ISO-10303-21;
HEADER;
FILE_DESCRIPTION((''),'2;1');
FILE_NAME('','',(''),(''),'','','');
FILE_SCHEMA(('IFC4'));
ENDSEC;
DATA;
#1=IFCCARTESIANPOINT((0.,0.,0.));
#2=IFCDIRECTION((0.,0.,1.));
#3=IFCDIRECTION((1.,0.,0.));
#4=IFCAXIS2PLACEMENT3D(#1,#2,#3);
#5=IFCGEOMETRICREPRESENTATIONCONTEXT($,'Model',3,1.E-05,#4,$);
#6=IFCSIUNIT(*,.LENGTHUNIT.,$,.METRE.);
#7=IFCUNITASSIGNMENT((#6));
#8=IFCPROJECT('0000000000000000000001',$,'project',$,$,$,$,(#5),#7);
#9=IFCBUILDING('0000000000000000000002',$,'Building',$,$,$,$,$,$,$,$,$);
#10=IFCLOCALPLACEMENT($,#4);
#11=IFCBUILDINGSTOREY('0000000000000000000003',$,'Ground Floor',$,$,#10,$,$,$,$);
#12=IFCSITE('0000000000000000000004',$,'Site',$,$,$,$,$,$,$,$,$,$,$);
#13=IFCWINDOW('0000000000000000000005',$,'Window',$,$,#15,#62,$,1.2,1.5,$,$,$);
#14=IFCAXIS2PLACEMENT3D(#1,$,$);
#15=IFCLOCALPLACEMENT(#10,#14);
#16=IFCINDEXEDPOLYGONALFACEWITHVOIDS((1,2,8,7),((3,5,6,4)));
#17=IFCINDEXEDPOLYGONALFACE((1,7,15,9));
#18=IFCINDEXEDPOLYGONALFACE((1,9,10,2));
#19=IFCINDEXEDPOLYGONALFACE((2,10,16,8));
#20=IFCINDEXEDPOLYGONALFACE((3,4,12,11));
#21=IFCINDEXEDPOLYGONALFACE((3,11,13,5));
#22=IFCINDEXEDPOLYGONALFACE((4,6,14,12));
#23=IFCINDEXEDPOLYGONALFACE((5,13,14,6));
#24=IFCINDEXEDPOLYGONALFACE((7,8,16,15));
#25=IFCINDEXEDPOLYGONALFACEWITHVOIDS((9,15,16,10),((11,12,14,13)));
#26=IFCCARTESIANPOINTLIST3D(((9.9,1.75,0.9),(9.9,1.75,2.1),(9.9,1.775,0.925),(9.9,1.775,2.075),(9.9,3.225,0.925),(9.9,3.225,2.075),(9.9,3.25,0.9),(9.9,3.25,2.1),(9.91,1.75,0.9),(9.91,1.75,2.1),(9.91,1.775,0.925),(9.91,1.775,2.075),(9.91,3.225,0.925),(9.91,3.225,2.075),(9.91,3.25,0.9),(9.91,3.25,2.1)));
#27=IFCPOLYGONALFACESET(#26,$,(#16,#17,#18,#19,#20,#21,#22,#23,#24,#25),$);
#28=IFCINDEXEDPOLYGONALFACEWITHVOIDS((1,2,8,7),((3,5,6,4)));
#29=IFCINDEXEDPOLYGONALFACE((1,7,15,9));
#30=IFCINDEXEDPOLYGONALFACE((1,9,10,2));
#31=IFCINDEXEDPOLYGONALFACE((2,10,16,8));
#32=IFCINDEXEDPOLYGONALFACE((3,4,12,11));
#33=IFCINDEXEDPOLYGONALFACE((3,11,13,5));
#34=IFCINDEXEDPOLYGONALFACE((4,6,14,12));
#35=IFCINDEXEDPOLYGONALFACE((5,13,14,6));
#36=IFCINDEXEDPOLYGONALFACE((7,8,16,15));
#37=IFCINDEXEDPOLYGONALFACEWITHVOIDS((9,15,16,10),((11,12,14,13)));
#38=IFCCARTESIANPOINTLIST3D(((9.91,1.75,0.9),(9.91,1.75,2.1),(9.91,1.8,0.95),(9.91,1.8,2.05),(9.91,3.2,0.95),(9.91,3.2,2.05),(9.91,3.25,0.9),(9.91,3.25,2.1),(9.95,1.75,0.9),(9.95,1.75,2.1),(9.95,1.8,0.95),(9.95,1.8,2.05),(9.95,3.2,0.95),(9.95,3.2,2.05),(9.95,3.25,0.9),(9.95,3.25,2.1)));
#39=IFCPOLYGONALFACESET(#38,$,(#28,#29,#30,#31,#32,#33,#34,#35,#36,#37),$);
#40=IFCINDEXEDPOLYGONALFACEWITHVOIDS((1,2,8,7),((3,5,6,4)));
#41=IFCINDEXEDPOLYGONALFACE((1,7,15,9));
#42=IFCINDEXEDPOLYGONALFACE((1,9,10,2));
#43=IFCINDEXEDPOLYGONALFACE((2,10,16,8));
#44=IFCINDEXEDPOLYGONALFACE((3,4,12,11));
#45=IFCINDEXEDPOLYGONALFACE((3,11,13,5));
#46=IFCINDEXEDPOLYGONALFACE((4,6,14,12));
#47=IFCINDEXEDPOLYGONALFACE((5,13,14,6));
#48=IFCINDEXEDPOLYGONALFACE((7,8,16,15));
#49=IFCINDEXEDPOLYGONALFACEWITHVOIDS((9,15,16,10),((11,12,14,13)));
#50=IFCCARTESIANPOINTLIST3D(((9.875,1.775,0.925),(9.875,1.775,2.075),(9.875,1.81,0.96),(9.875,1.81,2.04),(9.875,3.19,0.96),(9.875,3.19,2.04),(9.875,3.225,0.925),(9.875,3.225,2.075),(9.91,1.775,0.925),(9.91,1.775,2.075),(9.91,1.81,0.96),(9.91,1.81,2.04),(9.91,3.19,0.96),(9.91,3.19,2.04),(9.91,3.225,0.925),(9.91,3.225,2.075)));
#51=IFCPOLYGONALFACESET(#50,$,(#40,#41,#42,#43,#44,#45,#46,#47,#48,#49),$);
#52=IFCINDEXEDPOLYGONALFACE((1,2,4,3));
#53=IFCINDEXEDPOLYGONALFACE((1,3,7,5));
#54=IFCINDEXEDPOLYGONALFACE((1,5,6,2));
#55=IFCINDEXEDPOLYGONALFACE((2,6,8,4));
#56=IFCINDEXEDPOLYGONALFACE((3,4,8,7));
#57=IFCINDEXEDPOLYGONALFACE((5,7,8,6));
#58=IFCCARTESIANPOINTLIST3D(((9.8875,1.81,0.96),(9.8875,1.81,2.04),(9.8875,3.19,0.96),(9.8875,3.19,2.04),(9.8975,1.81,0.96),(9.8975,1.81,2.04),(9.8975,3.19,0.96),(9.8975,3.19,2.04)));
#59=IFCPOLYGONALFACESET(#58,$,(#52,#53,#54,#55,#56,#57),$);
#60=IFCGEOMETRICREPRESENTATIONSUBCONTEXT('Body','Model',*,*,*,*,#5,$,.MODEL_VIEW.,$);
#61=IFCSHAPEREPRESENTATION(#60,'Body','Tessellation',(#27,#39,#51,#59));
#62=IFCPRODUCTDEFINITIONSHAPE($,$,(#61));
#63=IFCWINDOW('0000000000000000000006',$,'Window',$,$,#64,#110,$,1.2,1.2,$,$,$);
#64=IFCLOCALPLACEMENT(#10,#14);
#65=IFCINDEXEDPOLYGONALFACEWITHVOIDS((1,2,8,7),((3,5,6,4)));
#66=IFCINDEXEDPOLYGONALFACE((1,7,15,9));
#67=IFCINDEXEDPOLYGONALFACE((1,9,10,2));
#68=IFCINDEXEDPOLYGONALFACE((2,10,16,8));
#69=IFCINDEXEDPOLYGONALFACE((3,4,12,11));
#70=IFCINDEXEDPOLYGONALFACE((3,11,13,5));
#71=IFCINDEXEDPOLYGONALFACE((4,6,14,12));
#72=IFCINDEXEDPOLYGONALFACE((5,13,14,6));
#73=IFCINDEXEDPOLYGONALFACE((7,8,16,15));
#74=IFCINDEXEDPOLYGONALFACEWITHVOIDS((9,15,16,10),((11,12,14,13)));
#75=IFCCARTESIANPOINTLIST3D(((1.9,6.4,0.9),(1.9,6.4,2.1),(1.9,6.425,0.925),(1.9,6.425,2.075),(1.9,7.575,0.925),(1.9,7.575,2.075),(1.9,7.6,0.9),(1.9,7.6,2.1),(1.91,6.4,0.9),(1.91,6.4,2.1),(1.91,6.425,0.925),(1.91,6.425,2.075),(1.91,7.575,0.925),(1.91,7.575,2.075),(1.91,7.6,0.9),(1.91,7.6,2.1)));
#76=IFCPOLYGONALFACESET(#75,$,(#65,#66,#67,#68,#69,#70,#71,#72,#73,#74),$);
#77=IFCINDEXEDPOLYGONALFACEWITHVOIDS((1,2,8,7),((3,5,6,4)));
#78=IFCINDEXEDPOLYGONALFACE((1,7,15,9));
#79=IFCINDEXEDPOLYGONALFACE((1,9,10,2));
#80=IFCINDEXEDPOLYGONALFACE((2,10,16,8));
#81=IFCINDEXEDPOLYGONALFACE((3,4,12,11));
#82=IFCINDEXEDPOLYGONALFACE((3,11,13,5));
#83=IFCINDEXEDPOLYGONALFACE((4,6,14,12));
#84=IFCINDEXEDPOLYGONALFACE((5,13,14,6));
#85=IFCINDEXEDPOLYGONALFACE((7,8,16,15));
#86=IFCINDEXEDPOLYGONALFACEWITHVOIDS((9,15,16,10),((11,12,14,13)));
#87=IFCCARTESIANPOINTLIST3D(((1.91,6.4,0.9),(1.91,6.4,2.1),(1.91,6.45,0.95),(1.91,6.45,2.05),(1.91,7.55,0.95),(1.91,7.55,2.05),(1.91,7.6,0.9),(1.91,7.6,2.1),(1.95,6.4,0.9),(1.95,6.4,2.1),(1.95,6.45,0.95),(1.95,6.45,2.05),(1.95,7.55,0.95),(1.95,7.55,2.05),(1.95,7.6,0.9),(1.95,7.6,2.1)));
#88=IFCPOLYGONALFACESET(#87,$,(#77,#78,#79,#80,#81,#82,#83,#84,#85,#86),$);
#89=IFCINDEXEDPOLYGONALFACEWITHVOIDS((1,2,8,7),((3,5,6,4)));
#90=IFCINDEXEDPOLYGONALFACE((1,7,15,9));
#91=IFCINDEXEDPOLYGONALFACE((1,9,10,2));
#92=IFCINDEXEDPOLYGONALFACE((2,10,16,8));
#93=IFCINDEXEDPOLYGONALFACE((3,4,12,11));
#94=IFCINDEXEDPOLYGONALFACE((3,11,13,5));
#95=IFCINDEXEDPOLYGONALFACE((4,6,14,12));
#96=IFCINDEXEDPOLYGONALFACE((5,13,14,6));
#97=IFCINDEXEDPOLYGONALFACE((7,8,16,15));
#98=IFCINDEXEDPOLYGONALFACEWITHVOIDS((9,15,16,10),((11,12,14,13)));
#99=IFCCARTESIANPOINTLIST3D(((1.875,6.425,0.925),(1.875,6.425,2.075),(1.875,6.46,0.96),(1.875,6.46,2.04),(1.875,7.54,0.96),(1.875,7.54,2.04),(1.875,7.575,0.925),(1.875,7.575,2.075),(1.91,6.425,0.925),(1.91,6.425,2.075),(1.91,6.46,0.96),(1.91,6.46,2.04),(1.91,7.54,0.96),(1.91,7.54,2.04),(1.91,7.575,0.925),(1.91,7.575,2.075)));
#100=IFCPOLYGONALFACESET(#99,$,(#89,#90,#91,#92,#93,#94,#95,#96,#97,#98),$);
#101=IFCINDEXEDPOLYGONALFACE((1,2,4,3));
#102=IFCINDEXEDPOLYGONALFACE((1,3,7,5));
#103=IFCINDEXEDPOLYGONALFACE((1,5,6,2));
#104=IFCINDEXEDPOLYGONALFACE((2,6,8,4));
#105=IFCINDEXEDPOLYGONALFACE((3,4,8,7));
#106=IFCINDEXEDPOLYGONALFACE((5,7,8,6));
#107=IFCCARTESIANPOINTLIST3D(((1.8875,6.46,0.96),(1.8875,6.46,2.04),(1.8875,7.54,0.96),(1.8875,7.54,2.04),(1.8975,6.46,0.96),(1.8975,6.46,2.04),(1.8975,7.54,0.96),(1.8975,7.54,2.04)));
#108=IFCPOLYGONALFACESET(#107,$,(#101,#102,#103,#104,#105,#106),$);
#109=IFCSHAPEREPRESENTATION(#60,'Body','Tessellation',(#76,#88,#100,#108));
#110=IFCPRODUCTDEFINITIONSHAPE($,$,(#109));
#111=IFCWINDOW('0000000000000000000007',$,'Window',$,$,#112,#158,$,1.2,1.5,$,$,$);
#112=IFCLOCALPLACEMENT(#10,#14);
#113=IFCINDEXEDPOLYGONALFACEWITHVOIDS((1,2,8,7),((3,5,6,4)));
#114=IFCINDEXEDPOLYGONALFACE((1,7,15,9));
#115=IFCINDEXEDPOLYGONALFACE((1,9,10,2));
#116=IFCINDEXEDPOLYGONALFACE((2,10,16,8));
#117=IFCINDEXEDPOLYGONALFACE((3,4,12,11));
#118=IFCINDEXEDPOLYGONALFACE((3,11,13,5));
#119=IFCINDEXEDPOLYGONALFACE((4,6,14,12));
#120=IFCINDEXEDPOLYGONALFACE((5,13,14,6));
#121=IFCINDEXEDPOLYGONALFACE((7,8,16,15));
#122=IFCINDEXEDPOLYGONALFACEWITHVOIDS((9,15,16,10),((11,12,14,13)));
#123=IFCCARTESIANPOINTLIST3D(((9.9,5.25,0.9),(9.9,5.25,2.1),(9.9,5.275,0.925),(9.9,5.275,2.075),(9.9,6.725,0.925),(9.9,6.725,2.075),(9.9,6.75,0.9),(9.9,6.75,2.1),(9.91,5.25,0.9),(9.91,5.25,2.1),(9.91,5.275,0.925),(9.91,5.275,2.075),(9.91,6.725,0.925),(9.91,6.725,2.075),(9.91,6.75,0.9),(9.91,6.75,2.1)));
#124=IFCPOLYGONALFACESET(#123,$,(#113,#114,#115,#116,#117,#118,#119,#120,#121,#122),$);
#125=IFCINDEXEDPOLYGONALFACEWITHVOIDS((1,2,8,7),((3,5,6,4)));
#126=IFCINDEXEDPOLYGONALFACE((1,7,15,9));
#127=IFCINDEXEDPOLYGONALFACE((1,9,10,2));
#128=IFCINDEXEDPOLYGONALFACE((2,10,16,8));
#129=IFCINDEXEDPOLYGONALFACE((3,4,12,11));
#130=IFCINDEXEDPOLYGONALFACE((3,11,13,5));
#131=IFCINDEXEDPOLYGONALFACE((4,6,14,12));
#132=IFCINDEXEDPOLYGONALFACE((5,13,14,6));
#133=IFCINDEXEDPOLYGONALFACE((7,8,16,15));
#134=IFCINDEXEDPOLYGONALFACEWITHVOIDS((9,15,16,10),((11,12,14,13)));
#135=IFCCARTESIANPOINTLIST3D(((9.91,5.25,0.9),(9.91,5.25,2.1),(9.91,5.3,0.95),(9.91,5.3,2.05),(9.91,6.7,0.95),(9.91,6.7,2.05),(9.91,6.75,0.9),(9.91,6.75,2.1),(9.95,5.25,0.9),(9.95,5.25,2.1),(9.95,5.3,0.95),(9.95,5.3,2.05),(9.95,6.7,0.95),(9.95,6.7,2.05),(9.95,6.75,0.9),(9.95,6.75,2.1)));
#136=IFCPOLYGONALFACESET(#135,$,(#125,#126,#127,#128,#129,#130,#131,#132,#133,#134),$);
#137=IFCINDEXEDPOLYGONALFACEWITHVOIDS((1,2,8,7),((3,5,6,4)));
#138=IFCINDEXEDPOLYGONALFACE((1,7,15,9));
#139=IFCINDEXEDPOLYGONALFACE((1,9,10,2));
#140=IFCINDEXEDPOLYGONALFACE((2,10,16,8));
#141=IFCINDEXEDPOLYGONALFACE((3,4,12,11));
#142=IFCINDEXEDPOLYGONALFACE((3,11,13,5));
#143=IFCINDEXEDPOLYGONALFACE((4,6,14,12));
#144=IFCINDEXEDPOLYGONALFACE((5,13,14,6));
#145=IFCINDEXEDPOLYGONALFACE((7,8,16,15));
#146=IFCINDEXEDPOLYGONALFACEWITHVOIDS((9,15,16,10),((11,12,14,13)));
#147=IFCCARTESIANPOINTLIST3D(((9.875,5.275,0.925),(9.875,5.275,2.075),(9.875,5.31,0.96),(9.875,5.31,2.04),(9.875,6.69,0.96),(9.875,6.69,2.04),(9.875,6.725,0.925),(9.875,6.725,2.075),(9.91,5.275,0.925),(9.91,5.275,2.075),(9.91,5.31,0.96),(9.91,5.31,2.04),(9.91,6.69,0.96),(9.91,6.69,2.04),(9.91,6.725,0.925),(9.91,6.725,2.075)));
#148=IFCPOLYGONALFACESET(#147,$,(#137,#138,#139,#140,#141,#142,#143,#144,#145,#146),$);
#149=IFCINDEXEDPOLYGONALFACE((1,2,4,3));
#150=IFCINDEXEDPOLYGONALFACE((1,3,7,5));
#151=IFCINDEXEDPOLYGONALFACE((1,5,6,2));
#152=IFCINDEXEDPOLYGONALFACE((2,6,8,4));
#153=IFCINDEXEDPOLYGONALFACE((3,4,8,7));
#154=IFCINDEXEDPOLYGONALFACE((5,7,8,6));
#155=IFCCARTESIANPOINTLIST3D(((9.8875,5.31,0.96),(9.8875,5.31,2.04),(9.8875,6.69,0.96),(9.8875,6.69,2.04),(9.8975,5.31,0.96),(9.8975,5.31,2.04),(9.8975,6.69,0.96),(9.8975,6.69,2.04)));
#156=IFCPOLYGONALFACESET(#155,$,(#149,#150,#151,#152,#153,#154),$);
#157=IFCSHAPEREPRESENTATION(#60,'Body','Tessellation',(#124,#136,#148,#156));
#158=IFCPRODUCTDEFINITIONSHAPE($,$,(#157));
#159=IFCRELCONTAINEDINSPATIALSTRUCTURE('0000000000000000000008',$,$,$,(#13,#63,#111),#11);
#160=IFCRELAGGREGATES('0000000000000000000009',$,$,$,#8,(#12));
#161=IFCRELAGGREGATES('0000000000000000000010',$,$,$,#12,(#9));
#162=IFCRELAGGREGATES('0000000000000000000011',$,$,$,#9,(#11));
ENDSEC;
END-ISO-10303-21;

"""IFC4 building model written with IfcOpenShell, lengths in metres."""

from ifc_helpers import new_model, si_unit, frame, origin_with_axes, place, context, subcontext, project, spatial, line, indexed_curve, outline, extrude, element, save


model = new_model("IFC4")

# Units and contexts
model_context = context("Model", 3, precision=1e-05, world=origin_with_axes())
body_context = subcontext(model_context, "Body", "Model", "MODEL_VIEW")
ifc_project = project(units=[si_unit("LENGTHUNIT", "METRE")], contexts=[model_context])

# Site, building, storey
site = spatial("IfcSite", under=ifc_project, Name="Site")
building = spatial("IfcBuilding", under=site, Name="Building")
storey_placement = place(None, origin_with_axes())
storey = spatial("IfcBuildingStorey", under=building, at=storey_placement, Name="Ground Floor")

# Windows
window_1_placement = place(storey_placement, frame((10.0, 1.75, 0.9), z_axis=(0.0, 0.0, 1.0), x_axis=(0.0, 1.0, 0.0)))
element("IfcWindow", 1, at=window_1_placement, inside=storey, Name="Window", OverallHeight=1.2, OverallWidth=1.5, context=body_context, shape_type="SweptSolid", body=[
    extrude(outline(indexed_curve([(0.0, 0.0), (1.5, 0.0), (1.5, 1.2), (0.0, 1.2)], segments=[line(1, 2, 3, 4, 1)]), holes=[indexed_curve([(0.025, 0.025), (1.475, 0.025), (1.475, 1.175), (0.025, 1.175)], segments=[line(1, 2, 3, 4, 1)])]), frame((0.0, 0.09, 0.0), z_axis=(0.0, -1.0, 0.0), x_axis=(1.0, 0.0, 0.0)), (0.0, 0.0, -1.0), 0.01),
    extrude(outline(indexed_curve([(0.0, 0.0), (1.5, 0.0), (1.5, 1.2), (0.0, 1.2)], segments=[line(1, 2, 3, 4, 1)]), holes=[indexed_curve([(0.05, 0.05), (1.45, 0.05), (1.45, 1.15), (0.05, 1.15)], segments=[line(1, 2, 3, 4, 1)])]), frame((0.0, 0.05, 0.0), z_axis=(0.0, -1.0, 0.0), x_axis=(1.0, 0.0, 0.0)), (0.0, 0.0, -1.0), 0.04),
    extrude(outline(indexed_curve([(0.0, 0.0), (1.45, 0.0), (1.45, 1.15), (0.0, 1.15)], segments=[line(1, 2, 3, 4, 1)]), holes=[indexed_curve([(0.035, 0.035), (1.415, 0.035), (1.415, 1.115), (0.035, 1.115)], segments=[line(1, 2, 3, 4, 1)])]), frame((0.025, 0.09, 0.025), z_axis=(0.0, -1.0, 0.0), x_axis=(1.0, 0.0, 0.0)), (0.0, 0.0, -1.0), 0.035),
    extrude(outline(indexed_curve([(0.035, 0.035), (1.415, 0.035), (1.415, 1.115), (0.035, 1.115)], segments=[line(1, 2, 3, 4, 1)])), frame((0.025, 0.1025, 0.025), z_axis=(0.0, -1.0, 0.0), x_axis=(1.0, 0.0, 0.0)), (0.0, 0.0, -1.0), 0.01),
])
window_2_placement = place(storey_placement, frame((2.0, 6.4, 0.9), z_axis=(0.0, 0.0, 1.0), x_axis=(0.0, 1.0, 0.0)))
element("IfcWindow", 2, at=window_2_placement, inside=storey, Name="Window", OverallHeight=1.2, OverallWidth=1.2, context=body_context, shape_type="SweptSolid", body=[
    extrude(outline(indexed_curve([(0.0, 0.0), (1.2, 0.0), (1.2, 1.2), (0.0, 1.2)], segments=[line(1, 2, 3, 4, 1)]), holes=[indexed_curve([(0.025, 0.025), (1.175, 0.025), (1.175, 1.175), (0.025, 1.175)], segments=[line(1, 2, 3, 4, 1)])]), frame((0.0, 0.09, 0.0), z_axis=(0.0, -1.0, 0.0), x_axis=(1.0, 0.0, 0.0)), (0.0, 0.0, -1.0), 0.01),
    extrude(outline(indexed_curve([(0.0, 0.0), (1.2, 0.0), (1.2, 1.2), (0.0, 1.2)], segments=[line(1, 2, 3, 4, 1)]), holes=[indexed_curve([(0.05, 0.05), (1.15, 0.05), (1.15, 1.15), (0.05, 1.15)], segments=[line(1, 2, 3, 4, 1)])]), frame((0.0, 0.05, 0.0), z_axis=(0.0, -1.0, 0.0), x_axis=(1.0, 0.0, 0.0)), (0.0, 0.0, -1.0), 0.04),
    extrude(outline(indexed_curve([(0.0, 0.0), (1.15, 0.0), (1.15, 1.15), (0.0, 1.15)], segments=[line(1, 2, 3, 4, 1)]), holes=[indexed_curve([(0.035, 0.035), (1.115, 0.035), (1.115, 1.115), (0.035, 1.115)], segments=[line(1, 2, 3, 4, 1)])]), frame((0.025, 0.09, 0.025), z_axis=(0.0, -1.0, 0.0), x_axis=(1.0, 0.0, 0.0)), (0.0, 0.0, -1.0), 0.035),
    extrude(outline(indexed_curve([(0.035, 0.035), (1.115, 0.035), (1.115, 1.115), (0.035, 1.115)], segments=[line(1, 2, 3, 4, 1)])), frame((0.025, 0.1025, 0.025), z_axis=(0.0, -1.0, 0.0), x_axis=(1.0, 0.0, 0.0)), (0.0, 0.0, -1.0), 0.01),
])
window_3_placement = place(storey_placement, frame((10.0, 5.25, 0.9), z_axis=(0.0, 0.0, 1.0), x_axis=(0.0, 1.0, 0.0)))
element("IfcWindow", 3, at=window_3_placement, inside=storey, Name="Window", OverallHeight=1.2, OverallWidth=1.5, context=body_context, shape_type="SweptSolid", body=[
    extrude(outline(indexed_curve([(0.0, 0.0), (1.5, 0.0), (1.5, 1.2), (0.0, 1.2)], segments=[line(1, 2, 3, 4, 1)]), holes=[indexed_curve([(0.025, 0.025), (1.475, 0.025), (1.475, 1.175), (0.025, 1.175)], segments=[line(1, 2, 3, 4, 1)])]), frame((0.0, 0.09, 0.0), z_axis=(0.0, -1.0, 0.0), x_axis=(1.0, 0.0, 0.0)), (0.0, 0.0, -1.0), 0.01),
    extrude(outline(indexed_curve([(0.0, 0.0), (1.5, 0.0), (1.5, 1.2), (0.0, 1.2)], segments=[line(1, 2, 3, 4, 1)]), holes=[indexed_curve([(0.05, 0.05), (1.45, 0.05), (1.45, 1.15), (0.05, 1.15)], segments=[line(1, 2, 3, 4, 1)])]), frame((0.0, 0.05, 0.0), z_axis=(0.0, -1.0, 0.0), x_axis=(1.0, 0.0, 0.0)), (0.0, 0.0, -1.0), 0.04),
    extrude(outline(indexed_curve([(0.0, 0.0), (1.45, 0.0), (1.45, 1.15), (0.0, 1.15)], segments=[line(1, 2, 3, 4, 1)]), holes=[indexed_curve([(0.035, 0.035), (1.415, 0.035), (1.415, 1.115), (0.035, 1.115)], segments=[line(1, 2, 3, 4, 1)])]), frame((0.025, 0.09, 0.025), z_axis=(0.0, -1.0, 0.0), x_axis=(1.0, 0.0, 0.0)), (0.0, 0.0, -1.0), 0.035),
    extrude(outline(indexed_curve([(0.035, 0.035), (1.415, 0.035), (1.415, 1.115), (0.035, 1.115)], segments=[line(1, 2, 3, 4, 1)])), frame((0.025, 0.1025, 0.025), z_axis=(0.0, -1.0, 0.0), x_axis=(1.0, 0.0, 0.0)), (0.0, 0.0, -1.0), 0.01),
])

save(model, "model.ifc")
